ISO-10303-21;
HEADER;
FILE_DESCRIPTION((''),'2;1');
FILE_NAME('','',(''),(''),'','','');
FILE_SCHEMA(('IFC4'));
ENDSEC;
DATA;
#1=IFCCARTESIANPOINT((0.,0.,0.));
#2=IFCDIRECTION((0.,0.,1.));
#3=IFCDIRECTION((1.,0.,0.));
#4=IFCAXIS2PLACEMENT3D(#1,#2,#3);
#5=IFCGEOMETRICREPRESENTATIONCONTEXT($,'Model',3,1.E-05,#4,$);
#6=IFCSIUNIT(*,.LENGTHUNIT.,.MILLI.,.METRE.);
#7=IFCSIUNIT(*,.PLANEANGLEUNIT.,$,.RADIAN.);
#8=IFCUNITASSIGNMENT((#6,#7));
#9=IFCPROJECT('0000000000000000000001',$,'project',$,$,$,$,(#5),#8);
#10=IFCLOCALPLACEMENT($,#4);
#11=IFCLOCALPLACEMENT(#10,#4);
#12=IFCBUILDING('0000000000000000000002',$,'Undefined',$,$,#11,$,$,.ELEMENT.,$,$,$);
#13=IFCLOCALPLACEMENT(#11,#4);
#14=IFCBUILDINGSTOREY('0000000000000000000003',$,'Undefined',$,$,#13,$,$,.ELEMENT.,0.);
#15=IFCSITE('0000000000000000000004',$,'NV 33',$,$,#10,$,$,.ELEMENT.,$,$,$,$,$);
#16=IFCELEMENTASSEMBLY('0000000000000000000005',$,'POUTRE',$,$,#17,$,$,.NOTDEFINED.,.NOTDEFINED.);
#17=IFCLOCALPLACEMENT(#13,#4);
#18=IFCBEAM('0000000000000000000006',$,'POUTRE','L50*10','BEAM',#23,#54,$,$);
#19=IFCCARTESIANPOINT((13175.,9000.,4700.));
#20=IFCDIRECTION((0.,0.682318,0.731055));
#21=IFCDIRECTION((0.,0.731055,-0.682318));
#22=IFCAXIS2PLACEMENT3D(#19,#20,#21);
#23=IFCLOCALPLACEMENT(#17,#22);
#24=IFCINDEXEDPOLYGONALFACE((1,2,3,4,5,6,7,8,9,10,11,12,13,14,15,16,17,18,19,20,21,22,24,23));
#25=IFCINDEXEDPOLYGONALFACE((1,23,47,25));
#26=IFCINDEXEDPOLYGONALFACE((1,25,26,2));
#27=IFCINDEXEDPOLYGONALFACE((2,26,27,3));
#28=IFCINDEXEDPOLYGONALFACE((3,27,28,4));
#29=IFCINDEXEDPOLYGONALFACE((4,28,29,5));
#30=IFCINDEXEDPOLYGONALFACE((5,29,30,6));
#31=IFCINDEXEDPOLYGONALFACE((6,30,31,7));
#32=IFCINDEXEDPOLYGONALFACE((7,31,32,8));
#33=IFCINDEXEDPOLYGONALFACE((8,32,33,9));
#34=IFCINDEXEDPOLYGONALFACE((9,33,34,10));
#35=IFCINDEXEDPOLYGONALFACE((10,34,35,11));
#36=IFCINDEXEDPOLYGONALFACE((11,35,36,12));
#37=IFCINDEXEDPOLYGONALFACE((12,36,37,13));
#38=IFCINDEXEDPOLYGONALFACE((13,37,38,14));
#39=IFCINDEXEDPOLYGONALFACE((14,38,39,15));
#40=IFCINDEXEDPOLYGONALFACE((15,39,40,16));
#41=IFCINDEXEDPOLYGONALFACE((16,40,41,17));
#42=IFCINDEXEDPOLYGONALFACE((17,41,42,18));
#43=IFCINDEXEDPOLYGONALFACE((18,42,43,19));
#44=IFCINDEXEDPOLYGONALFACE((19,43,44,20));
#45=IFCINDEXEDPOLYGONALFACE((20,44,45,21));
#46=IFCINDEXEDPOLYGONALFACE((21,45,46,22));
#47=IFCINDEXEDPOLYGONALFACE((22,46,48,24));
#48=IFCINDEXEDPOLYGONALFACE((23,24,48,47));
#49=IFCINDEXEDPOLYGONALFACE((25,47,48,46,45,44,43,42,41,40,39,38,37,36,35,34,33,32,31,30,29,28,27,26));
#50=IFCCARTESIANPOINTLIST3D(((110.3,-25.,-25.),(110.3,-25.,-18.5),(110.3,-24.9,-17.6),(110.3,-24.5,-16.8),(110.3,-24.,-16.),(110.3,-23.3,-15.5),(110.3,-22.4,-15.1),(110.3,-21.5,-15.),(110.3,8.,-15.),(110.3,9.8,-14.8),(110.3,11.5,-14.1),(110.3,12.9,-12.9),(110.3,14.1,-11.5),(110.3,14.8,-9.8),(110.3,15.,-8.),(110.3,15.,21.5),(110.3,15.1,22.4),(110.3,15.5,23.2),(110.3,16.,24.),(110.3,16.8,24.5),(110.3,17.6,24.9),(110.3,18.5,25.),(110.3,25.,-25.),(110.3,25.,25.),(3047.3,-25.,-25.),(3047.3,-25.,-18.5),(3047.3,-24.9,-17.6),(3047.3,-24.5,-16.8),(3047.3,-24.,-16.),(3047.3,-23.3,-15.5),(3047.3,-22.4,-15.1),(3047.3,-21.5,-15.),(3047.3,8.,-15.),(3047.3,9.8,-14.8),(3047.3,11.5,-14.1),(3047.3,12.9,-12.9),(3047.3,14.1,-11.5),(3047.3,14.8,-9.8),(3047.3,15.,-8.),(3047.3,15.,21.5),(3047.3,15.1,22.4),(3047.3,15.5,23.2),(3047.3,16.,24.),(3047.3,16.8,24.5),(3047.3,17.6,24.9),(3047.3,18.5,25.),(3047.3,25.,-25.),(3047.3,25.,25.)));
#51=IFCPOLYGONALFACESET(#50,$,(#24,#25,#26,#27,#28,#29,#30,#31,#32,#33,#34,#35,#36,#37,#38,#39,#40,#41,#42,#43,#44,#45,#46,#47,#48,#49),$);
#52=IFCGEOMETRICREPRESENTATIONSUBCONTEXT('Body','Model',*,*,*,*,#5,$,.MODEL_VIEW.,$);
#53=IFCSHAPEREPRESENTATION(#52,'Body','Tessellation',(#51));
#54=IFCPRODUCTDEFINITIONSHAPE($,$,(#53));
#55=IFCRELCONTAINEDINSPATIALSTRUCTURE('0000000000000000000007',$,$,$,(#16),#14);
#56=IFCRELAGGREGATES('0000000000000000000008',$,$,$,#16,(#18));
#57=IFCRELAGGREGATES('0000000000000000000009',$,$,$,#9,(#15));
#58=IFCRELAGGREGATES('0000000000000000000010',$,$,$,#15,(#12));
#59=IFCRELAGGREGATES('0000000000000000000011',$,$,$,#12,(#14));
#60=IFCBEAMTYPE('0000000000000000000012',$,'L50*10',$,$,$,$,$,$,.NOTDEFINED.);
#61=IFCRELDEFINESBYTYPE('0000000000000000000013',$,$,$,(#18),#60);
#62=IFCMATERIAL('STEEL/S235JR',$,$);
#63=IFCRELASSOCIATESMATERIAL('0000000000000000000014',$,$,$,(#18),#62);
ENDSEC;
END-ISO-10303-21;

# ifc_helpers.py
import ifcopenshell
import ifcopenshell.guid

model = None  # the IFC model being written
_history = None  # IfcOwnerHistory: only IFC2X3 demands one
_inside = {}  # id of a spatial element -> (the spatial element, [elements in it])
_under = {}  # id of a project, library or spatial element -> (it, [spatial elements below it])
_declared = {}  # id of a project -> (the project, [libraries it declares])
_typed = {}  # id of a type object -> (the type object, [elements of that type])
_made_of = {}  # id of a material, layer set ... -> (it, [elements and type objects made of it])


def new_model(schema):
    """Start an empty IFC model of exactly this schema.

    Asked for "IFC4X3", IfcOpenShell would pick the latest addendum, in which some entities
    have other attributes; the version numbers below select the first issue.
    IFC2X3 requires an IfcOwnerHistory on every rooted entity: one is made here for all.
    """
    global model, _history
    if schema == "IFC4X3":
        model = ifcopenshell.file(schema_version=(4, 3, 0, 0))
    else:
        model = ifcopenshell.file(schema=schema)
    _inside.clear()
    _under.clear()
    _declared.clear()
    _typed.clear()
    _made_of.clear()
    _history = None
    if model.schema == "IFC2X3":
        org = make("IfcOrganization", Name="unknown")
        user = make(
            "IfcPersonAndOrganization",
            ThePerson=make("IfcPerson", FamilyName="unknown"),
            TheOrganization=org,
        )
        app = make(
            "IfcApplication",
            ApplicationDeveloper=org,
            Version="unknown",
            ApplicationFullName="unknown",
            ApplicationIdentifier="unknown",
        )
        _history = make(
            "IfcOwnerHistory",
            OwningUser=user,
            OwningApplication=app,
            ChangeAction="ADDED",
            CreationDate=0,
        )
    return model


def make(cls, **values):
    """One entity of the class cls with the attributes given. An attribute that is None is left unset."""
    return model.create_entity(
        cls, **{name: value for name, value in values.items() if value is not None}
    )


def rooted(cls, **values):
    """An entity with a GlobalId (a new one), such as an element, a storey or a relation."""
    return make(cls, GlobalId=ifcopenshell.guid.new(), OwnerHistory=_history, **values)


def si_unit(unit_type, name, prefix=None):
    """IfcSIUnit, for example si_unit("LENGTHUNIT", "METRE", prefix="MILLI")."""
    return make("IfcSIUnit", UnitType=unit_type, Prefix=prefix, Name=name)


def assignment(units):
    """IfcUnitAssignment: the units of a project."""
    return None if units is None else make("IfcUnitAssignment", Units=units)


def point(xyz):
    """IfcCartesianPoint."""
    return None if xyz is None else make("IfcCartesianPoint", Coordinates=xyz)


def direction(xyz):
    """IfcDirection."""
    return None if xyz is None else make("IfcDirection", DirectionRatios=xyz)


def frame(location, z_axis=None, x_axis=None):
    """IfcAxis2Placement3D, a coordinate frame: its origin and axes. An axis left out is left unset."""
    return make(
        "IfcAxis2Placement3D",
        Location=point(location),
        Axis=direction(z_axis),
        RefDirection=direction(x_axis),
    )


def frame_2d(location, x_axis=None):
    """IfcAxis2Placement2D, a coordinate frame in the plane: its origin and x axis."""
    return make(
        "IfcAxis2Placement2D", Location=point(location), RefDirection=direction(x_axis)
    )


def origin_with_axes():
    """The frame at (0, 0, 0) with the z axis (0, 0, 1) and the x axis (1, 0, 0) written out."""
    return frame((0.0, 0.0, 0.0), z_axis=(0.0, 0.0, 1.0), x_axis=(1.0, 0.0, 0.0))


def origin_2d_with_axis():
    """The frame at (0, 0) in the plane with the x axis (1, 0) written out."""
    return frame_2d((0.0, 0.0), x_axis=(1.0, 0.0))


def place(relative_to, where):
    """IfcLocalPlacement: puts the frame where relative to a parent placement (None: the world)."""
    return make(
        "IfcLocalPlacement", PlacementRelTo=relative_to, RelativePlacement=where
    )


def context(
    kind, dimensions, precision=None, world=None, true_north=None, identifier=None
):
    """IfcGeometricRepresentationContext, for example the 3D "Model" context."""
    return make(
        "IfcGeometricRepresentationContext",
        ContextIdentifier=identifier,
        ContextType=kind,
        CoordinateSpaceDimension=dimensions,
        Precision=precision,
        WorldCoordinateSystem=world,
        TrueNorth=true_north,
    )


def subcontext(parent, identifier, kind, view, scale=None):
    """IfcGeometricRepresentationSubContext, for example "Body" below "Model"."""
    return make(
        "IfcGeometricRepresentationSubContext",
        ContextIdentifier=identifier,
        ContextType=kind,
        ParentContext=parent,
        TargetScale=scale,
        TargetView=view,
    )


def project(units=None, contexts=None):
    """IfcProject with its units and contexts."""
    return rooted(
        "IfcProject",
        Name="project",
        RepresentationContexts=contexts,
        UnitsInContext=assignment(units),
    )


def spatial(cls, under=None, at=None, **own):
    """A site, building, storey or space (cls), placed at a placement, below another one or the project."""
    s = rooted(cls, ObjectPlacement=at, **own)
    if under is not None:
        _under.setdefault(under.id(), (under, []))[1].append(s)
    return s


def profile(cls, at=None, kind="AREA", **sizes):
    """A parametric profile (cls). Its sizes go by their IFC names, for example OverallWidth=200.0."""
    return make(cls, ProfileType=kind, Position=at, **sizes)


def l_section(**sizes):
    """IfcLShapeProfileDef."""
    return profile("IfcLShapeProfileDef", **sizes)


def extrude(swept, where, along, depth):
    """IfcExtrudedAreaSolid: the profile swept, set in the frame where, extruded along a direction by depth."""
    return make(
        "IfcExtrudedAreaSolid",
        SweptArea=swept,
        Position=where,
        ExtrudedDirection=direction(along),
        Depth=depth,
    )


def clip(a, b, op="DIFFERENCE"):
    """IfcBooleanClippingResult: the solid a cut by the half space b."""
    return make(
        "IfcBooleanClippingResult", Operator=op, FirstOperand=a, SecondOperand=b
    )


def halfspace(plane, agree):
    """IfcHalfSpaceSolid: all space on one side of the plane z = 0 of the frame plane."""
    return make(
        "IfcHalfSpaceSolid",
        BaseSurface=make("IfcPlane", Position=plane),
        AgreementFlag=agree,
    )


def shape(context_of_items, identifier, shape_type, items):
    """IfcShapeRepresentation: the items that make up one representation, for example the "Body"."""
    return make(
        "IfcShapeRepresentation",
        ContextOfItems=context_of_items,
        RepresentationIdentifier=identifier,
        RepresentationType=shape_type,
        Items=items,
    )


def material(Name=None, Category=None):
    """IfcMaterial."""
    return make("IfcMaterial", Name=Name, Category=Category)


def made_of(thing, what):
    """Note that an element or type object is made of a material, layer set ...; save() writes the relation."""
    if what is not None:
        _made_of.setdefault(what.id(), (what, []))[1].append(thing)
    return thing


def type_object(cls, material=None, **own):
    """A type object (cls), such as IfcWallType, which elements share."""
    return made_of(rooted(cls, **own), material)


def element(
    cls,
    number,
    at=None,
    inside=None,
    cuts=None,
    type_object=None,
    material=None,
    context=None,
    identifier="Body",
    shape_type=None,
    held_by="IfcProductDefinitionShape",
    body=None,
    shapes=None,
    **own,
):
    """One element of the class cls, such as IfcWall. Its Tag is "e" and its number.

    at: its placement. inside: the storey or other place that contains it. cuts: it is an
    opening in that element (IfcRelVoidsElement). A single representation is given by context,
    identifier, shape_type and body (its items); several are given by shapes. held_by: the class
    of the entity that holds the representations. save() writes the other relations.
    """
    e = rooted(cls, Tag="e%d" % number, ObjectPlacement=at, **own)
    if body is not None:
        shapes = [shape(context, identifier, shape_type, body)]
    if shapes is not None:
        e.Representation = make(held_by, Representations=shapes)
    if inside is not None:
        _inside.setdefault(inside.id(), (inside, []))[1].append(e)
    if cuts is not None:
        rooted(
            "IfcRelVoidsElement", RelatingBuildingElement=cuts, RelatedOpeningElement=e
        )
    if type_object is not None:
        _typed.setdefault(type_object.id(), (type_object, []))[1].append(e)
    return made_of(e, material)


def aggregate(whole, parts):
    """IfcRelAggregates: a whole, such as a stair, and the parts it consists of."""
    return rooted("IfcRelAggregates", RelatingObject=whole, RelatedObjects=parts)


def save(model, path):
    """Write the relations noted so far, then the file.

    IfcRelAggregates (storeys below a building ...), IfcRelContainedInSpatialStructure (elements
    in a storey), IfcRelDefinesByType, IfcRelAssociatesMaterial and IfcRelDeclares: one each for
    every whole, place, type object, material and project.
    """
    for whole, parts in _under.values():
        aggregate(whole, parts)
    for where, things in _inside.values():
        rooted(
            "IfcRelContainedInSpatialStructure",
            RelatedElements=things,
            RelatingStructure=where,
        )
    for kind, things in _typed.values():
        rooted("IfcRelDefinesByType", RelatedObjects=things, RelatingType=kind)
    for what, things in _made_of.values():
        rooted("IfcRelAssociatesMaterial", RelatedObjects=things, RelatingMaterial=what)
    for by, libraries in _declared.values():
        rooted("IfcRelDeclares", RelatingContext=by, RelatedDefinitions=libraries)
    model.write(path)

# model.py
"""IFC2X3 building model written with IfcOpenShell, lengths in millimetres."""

from ifc_helpers import new_model, si_unit, frame, origin_with_axes, origin_2d_with_axis, place, context, subcontext, project, spatial, l_section, extrude, clip, halfspace, material, type_object, element, aggregate, save


model = new_model("IFC2X3")

# Units and contexts
model_context = context("Model", 3, precision=1e-05, world=origin_with_axes())
body_context = subcontext(model_context, "Body", "Model", "MODEL_VIEW")
ifc_project = project(units=[si_unit("LENGTHUNIT", "METRE", prefix="MILLI"), si_unit("PLANEANGLEUNIT", "RADIAN")], contexts=[model_context])

# Site, building, storey
site_placement = place(None, origin_with_axes())
site = spatial("IfcSite", under=ifc_project, at=site_placement, Name="NV 33", CompositionType="ELEMENT")
building_placement = place(site_placement, origin_with_axes())
building = spatial("IfcBuilding", under=site, at=building_placement, Name="Undefined", CompositionType="ELEMENT")
storey_placement = place(building_placement, origin_with_axes())
storey = spatial("IfcBuildingStorey", under=building, at=storey_placement, Name="Undefined", CompositionType="ELEMENT", Elevation=0.0)

# Shared definitions
ifc_material_1 = material(Name="STEEL/S235JR")

# Element assembly, beam
assembly_1_placement = place(storey_placement, origin_with_axes())
assembly_1 = element("IfcElementAssembly", 1, at=assembly_1_placement, inside=storey, Name="POUTRE", AssemblyPlace="NOTDEFINED", PredefinedType="NOTDEFINED")
beam_type_1 = type_object("IfcBeamType", Name="L50*10", PredefinedType="NOTDEFINED")
beam_1_placement = place(assembly_1_placement, frame((13175.0, 9000.0, 4700.0), z_axis=(0.0, 0.682318, 0.731055), x_axis=(0.0, 0.731055, -0.682318)))
beam_1 = element("IfcBeam", 2, at=beam_1_placement, type_object=beam_type_1, material=ifc_material_1, Name="POUTRE", Description="L50*10", ObjectType="BEAM", context=body_context, shape_type="Clipping", body=[
    clip(clip(extrude(l_section(Depth=50.0, Width=50.0, Thickness=10.0, FilletRadius=7.0, EdgeRadius=3.5, at=origin_2d_with_axis()), frame((3097.7, 0.0, 0.0), z_axis=(-1.0, 0.0, 0.0), x_axis=(0.0, -1.0, 0.0)), (0.0, 0.0, 1.0), 3097.7), halfspace(frame((3047.3, 0.0, -25.0), z_axis=(-1.0, 0.0, 0.0), x_axis=(0.0, 1.0, 0.0)), True)), halfspace(frame((110.3, 31.0, 0.0), z_axis=(1.0, 0.0, 0.0), x_axis=(0.0, 0.0, -1.0)), True)),
])
aggregate(assembly_1, [beam_1])

save(model, "model.ifc")
